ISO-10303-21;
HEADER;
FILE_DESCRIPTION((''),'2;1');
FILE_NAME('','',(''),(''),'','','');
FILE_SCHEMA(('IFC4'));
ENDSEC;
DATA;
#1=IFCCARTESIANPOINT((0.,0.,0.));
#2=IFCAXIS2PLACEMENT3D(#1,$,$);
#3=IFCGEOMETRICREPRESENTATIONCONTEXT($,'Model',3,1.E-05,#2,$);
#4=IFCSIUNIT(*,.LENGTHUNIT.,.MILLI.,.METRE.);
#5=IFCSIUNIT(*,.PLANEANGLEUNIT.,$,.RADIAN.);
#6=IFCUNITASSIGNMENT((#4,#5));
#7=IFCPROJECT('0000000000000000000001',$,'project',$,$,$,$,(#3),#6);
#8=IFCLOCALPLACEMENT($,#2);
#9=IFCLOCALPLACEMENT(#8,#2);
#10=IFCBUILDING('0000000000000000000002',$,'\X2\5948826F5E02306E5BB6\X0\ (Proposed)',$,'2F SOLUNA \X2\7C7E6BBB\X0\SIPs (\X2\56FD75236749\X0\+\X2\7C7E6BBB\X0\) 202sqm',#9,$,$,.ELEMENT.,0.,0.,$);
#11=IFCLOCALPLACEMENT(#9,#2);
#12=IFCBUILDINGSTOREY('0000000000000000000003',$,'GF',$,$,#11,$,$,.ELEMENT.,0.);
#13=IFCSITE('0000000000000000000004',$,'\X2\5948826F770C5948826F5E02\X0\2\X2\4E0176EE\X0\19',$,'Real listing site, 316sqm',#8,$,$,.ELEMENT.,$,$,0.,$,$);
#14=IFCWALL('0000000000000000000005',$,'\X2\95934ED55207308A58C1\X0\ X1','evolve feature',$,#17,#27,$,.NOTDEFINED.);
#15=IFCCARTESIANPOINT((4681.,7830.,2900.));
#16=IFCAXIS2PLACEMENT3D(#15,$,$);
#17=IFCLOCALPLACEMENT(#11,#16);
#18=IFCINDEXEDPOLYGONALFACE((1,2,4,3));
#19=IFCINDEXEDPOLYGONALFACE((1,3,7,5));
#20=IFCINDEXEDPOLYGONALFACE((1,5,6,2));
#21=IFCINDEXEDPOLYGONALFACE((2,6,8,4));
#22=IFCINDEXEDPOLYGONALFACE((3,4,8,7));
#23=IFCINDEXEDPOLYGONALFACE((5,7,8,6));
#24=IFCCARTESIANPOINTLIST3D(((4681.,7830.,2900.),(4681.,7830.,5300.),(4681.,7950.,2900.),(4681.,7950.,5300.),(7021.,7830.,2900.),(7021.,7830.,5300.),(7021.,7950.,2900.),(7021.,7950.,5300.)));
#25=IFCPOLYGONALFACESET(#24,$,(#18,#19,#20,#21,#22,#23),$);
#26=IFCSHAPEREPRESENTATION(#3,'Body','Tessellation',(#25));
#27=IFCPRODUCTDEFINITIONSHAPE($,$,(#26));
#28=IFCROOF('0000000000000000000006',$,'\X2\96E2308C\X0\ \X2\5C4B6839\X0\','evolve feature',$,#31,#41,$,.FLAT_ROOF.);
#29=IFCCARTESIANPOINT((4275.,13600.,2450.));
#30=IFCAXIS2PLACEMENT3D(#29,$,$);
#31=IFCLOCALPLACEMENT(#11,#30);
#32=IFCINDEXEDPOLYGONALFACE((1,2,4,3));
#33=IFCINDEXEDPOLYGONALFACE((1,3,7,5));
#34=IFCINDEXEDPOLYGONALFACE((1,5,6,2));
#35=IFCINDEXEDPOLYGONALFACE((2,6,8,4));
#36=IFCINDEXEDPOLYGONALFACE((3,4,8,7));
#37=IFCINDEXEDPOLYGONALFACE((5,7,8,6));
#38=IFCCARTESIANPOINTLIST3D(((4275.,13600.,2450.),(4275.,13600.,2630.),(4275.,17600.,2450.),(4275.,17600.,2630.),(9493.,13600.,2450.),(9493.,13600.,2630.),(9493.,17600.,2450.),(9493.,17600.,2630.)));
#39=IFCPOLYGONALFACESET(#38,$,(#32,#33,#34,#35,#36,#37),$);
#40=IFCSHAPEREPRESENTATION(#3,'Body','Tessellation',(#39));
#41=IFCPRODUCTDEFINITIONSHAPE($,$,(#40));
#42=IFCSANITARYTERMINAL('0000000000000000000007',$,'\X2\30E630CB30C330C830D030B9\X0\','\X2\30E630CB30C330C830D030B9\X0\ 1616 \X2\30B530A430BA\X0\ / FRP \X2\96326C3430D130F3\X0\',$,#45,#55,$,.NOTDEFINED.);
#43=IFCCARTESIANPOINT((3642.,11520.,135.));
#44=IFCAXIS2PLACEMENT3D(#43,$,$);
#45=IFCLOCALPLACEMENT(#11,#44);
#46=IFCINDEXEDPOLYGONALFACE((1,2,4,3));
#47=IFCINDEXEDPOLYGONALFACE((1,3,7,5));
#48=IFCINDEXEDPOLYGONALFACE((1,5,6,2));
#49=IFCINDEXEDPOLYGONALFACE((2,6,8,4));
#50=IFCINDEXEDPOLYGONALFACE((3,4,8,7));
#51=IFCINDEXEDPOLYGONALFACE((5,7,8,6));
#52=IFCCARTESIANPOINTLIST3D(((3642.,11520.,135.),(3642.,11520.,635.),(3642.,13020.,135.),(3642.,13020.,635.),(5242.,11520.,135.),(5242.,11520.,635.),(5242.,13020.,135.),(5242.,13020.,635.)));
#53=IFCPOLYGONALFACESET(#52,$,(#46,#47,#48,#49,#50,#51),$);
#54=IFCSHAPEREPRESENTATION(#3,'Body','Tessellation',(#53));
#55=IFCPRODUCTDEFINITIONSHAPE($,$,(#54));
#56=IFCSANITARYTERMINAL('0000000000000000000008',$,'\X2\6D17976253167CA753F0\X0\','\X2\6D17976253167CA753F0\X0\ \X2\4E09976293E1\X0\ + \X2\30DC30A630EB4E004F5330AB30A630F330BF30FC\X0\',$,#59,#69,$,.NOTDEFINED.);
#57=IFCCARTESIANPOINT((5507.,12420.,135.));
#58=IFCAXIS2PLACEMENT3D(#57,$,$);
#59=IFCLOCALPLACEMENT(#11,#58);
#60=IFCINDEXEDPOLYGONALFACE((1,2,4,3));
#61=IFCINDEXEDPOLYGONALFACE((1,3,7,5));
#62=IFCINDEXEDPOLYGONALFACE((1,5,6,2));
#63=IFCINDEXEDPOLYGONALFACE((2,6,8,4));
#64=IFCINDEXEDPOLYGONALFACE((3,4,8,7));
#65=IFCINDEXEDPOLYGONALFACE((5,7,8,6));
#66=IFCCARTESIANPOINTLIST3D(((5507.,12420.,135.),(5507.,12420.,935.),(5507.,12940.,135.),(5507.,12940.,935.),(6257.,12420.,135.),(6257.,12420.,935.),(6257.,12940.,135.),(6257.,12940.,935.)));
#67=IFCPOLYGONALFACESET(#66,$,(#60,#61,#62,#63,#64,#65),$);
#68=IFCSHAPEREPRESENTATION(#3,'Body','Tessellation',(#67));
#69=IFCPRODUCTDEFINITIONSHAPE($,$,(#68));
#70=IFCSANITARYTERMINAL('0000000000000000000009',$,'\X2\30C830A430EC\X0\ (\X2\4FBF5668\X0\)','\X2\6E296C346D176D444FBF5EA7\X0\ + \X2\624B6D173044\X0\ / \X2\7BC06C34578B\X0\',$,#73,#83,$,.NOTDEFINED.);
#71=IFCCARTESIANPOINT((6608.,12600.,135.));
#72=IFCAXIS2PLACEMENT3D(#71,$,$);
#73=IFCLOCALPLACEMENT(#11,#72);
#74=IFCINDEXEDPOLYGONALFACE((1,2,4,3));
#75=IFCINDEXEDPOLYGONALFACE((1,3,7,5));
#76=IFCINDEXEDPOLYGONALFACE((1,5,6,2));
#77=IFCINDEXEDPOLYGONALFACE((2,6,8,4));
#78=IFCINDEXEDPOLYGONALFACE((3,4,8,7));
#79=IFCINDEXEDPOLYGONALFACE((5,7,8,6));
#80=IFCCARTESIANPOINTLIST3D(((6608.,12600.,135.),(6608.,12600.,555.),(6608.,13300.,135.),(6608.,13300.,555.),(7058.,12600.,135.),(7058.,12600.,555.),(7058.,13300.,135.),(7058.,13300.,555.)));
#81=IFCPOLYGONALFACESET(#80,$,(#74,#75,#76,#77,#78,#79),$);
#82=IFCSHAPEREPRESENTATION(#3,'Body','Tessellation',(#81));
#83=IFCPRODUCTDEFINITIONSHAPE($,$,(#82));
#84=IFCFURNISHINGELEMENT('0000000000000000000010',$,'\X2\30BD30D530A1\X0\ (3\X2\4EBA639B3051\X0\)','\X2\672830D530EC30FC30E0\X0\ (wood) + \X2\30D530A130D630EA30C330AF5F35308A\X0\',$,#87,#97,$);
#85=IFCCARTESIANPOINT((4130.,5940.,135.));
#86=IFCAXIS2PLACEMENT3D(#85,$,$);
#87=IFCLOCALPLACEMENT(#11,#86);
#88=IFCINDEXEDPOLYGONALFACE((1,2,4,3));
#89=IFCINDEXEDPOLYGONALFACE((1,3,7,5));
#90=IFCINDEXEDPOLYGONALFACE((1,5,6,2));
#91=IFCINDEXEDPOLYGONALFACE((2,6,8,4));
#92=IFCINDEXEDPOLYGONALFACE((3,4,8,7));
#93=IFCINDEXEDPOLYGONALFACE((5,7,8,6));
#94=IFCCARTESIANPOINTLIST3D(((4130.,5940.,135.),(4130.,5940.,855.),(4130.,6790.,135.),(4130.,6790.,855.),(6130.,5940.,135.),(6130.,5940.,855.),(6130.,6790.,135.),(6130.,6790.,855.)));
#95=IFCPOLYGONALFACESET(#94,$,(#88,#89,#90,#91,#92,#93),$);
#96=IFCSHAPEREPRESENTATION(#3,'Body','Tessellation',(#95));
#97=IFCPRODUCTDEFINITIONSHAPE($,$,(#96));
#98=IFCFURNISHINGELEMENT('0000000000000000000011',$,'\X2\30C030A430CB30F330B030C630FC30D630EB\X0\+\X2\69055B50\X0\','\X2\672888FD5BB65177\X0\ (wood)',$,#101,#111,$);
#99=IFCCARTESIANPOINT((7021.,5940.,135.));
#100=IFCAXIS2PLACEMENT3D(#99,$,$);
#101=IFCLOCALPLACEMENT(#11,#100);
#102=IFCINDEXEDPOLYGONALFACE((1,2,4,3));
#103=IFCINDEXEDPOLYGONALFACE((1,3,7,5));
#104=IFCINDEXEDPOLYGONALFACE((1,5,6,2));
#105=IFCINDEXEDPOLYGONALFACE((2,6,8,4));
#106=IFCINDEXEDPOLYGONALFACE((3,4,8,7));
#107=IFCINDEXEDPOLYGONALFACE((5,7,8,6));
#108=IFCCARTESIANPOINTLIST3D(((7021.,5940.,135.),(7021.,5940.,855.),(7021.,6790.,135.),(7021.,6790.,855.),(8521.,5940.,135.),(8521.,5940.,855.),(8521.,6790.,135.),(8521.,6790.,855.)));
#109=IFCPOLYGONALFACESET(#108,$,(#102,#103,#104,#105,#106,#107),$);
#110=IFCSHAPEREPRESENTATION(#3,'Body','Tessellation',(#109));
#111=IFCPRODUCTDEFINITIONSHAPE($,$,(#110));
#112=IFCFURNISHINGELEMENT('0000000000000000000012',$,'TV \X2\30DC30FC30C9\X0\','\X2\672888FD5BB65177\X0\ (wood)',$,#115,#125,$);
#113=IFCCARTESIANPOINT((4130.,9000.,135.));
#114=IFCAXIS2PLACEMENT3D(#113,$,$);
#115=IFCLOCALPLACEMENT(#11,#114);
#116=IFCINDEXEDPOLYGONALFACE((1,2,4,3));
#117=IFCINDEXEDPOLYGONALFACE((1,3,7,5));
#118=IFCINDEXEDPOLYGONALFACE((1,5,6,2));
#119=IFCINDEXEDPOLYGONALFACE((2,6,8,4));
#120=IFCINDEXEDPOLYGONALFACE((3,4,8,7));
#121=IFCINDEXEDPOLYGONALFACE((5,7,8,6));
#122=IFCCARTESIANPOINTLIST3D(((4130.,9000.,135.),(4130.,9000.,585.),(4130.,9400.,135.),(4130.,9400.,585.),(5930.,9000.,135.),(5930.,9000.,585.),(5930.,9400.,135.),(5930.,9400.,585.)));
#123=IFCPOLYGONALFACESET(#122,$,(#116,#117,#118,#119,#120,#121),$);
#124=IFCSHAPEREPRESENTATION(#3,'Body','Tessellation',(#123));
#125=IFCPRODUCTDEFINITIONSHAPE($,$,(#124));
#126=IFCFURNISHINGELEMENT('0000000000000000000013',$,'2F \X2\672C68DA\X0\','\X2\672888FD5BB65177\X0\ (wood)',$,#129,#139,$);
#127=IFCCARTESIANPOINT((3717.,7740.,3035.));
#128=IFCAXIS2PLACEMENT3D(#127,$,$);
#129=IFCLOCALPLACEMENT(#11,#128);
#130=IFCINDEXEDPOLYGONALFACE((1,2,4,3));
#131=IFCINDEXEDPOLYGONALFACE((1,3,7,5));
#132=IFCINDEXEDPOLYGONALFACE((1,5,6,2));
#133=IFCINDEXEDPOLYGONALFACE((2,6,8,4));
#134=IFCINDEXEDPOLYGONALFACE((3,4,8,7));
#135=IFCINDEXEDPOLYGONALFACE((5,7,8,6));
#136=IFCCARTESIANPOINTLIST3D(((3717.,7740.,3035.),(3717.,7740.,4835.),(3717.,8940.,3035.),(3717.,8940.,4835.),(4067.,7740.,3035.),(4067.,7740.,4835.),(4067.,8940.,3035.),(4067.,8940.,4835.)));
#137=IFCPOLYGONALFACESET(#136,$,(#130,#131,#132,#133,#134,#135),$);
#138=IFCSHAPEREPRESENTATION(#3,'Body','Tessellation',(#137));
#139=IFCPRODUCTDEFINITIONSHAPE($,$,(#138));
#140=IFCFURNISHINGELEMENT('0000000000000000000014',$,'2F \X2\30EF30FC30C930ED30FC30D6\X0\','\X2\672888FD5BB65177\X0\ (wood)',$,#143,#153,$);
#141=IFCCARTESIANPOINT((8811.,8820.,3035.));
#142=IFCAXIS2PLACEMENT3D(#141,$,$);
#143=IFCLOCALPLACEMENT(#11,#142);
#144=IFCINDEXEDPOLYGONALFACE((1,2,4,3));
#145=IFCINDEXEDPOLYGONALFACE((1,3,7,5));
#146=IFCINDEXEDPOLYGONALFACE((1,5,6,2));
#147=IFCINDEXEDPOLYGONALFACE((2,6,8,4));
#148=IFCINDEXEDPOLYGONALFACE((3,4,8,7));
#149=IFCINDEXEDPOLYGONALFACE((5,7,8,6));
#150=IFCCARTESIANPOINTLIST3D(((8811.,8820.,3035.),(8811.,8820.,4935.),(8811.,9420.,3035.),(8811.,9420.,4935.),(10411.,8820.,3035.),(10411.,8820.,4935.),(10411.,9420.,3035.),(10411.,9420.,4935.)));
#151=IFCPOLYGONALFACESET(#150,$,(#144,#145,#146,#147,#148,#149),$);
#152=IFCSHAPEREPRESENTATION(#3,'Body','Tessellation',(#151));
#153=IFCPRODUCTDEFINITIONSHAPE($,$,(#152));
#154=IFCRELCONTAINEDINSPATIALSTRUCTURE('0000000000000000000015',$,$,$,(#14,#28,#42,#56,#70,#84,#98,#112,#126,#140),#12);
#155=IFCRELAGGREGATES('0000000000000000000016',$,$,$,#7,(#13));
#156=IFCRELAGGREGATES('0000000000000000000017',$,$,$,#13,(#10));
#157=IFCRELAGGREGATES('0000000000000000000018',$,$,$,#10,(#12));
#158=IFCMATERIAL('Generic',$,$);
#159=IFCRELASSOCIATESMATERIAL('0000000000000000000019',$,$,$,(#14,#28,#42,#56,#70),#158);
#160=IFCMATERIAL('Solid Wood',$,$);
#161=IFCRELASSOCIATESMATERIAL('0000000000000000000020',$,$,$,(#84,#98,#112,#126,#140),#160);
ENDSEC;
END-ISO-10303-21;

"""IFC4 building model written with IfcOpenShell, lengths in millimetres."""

from ifc_helpers import new_model, si_unit, frame, frame_2d, origin, place, context, project, spatial, rectangle, extrude, material, element, save


model = new_model("IFC4")

# Units and contexts
model_context = context("Model", 3, precision=1e-05, world=origin())
ifc_project = project(units=[si_unit("LENGTHUNIT", "METRE", prefix="MILLI"), si_unit("PLANEANGLEUNIT", "RADIAN")], contexts=[model_context])

# Site, building, storey
site_placement = place(None, origin())
site = spatial("IfcSite", under=ifc_project, at=site_placement, Name="奈良県奈良市2丁目19", ObjectType="Real listing site, 316sqm", CompositionType="ELEMENT", RefElevation=0.0)
building_placement = place(site_placement, origin())
building = spatial("IfcBuilding", under=site, at=building_placement, Name="奈良市の家 (Proposed)", ObjectType="2F SOLUNA 籾殻SIPs (国産杉+籾殻) 202sqm", CompositionType="ELEMENT", ElevationOfRefHeight=0.0, ElevationOfTerrain=0.0)
storey_placement = place(building_placement, origin())
storey = spatial("IfcBuildingStorey", under=building, at=storey_placement, Name="GF", CompositionType="ELEMENT", Elevation=0.0)

# Shared definitions
ifc_material_1 = material(Name="Generic")

# Shared definitions
ifc_material_2 = material(Name="Solid Wood")

# Wall
wall_1_placement = place(storey_placement, frame((4681.0, 7830.0, 2900.0)))
element("IfcWall", 1, at=wall_1_placement, inside=storey, material=ifc_material_1, Name="間仕切り壁 X1", Description="evolve feature", PredefinedType="NOTDEFINED", context=model_context, shape_type="SweptSolid", body=[
    extrude(rectangle(XDim=2340.0, YDim=120.0, at=frame_2d((1170.0, 60.0))), frame((4681.0, 7830.0, 2900.0)), (0.0, 0.0, 1.0), 2400.0),
])

# Roof
roof_placement = place(storey_placement, frame((4275.0, 13600.0, 2450.0)))
element("IfcRoof", 2, at=roof_placement, inside=storey, material=ifc_material_1, Name="離れ 屋根", Description="evolve feature", PredefinedType="FLAT_ROOF", context=model_context, shape_type="SweptSolid", body=[
    extrude(rectangle(XDim=5218.0, YDim=4000.0, at=frame_2d((2609.0, 2000.0))), frame((4275.0, 13600.0, 2450.0)), (0.0, 0.0, 1.0), 180.0),
])

# Sanitary terminals
sanitary_terminal_1_placement = place(storey_placement, frame((3642.0, 11520.0, 135.0)))
element("IfcSanitaryTerminal", 3, at=sanitary_terminal_1_placement, inside=storey, material=ifc_material_1, Name="ユニットバス", Description="ユニットバス 1616 サイズ / FRP 防水パン", PredefinedType="NOTDEFINED", context=model_context, shape_type="SweptSolid", body=[
    extrude(rectangle(XDim=1600.0, YDim=1500.0, at=frame_2d((800.0, 750.0))), frame((3642.0, 11520.0, 135.0)), (0.0, 0.0, 1.0), 500.0),
])
sanitary_terminal_2_placement = place(storey_placement, frame((5507.0, 12420.0, 135.0)))
element("IfcSanitaryTerminal", 4, at=sanitary_terminal_2_placement, inside=storey, material=ifc_material_1, Name="洗面化粧台", Description="洗面化粧台 三面鏡 + ボウル一体カウンター", PredefinedType="NOTDEFINED", context=model_context, shape_type="SweptSolid", body=[
    extrude(rectangle(XDim=750.0, YDim=520.0, at=frame_2d((375.0, 260.0))), frame((5507.0, 12420.0, 135.0)), (0.0, 0.0, 1.0), 800.0),
])
sanitary_terminal_3_placement = place(storey_placement, frame((6608.0, 12600.0, 135.0)))
element("IfcSanitaryTerminal", 5, at=sanitary_terminal_3_placement, inside=storey, material=ifc_material_1, Name="トイレ (便器)", Description="温水洗浄便座 + 手洗い / 節水型", PredefinedType="NOTDEFINED", context=model_context, shape_type="SweptSolid", body=[
    extrude(rectangle(XDim=450.0, YDim=700.0, at=frame_2d((225.0, 350.0))), frame((6608.0, 12600.0, 135.0)), (0.0, 0.0, 1.0), 420.0),
])

# Furnishing elements
furnishing_1_placement = place(storey_placement, frame((4130.0, 5940.0, 135.0)))
element("IfcFurnishingElement", 6, at=furnishing_1_placement, inside=storey, material=ifc_material_2, Name="ソファ (3人掛け)", Description="木フレーム (wood) + ファブリック張り", context=model_context, shape_type="SweptSolid", body=[
    extrude(rectangle(XDim=2000.0, YDim=850.0, at=frame_2d((1000.0, 425.0))), frame((4130.0, 5940.0, 135.0)), (0.0, 0.0, 1.0), 720.0),
])
furnishing_2_placement = place(storey_placement, frame((7021.0, 5940.0, 135.0)))
element("IfcFurnishingElement", 7, at=furnishing_2_placement, inside=storey, material=ifc_material_2, Name="ダイニングテーブル+椅子", Description="木製家具 (wood)", context=model_context, shape_type="SweptSolid", body=[
    extrude(rectangle(XDim=1500.0, YDim=850.0, at=frame_2d((750.0, 425.0))), frame((7021.0, 5940.0, 135.0)), (0.0, 0.0, 1.0), 720.0),
])
furnishing_3_placement = place(storey_placement, frame((4130.0, 9000.0, 135.0)))
element("IfcFurnishingElement", 8, at=furnishing_3_placement, inside=storey, material=ifc_material_2, Name="TV ボード", Description="木製家具 (wood)", context=model_context, shape_type="SweptSolid", body=[
    extrude(rectangle(XDim=1800.0, YDim=400.0, at=frame_2d((900.0, 200.0))), frame((4130.0, 9000.0, 135.0)), (0.0, 0.0, 1.0), 450.0),
])
furnishing_4_placement = place(storey_placement, frame((3717.0, 7740.0, 3035.0)))
element("IfcFurnishingElement", 9, at=furnishing_4_placement, inside=storey, material=ifc_material_2, Name="2F 本棚", Description="木製家具 (wood)", context=model_context, shape_type="SweptSolid", body=[
    extrude(rectangle(XDim=350.0, YDim=1200.0, at=frame_2d((175.0, 600.0))), frame((3717.0, 7740.0, 3035.0)), (0.0, 0.0, 1.0), 1800.0),
])
furnishing_5_placement = place(storey_placement, frame((8811.0, 8820.0, 3035.0)))
element("IfcFurnishingElement", 10, at=furnishing_5_placement, inside=storey, material=ifc_material_2, Name="2F ワードローブ", Description="木製家具 (wood)", context=model_context, shape_type="SweptSolid", body=[
    extrude(rectangle(XDim=1600.0, YDim=600.0, at=frame_2d((800.0, 300.0))), frame((8811.0, 8820.0, 3035.0)), (0.0, 0.0, 1.0), 1900.0),
])

save(model, "model.ifc")
